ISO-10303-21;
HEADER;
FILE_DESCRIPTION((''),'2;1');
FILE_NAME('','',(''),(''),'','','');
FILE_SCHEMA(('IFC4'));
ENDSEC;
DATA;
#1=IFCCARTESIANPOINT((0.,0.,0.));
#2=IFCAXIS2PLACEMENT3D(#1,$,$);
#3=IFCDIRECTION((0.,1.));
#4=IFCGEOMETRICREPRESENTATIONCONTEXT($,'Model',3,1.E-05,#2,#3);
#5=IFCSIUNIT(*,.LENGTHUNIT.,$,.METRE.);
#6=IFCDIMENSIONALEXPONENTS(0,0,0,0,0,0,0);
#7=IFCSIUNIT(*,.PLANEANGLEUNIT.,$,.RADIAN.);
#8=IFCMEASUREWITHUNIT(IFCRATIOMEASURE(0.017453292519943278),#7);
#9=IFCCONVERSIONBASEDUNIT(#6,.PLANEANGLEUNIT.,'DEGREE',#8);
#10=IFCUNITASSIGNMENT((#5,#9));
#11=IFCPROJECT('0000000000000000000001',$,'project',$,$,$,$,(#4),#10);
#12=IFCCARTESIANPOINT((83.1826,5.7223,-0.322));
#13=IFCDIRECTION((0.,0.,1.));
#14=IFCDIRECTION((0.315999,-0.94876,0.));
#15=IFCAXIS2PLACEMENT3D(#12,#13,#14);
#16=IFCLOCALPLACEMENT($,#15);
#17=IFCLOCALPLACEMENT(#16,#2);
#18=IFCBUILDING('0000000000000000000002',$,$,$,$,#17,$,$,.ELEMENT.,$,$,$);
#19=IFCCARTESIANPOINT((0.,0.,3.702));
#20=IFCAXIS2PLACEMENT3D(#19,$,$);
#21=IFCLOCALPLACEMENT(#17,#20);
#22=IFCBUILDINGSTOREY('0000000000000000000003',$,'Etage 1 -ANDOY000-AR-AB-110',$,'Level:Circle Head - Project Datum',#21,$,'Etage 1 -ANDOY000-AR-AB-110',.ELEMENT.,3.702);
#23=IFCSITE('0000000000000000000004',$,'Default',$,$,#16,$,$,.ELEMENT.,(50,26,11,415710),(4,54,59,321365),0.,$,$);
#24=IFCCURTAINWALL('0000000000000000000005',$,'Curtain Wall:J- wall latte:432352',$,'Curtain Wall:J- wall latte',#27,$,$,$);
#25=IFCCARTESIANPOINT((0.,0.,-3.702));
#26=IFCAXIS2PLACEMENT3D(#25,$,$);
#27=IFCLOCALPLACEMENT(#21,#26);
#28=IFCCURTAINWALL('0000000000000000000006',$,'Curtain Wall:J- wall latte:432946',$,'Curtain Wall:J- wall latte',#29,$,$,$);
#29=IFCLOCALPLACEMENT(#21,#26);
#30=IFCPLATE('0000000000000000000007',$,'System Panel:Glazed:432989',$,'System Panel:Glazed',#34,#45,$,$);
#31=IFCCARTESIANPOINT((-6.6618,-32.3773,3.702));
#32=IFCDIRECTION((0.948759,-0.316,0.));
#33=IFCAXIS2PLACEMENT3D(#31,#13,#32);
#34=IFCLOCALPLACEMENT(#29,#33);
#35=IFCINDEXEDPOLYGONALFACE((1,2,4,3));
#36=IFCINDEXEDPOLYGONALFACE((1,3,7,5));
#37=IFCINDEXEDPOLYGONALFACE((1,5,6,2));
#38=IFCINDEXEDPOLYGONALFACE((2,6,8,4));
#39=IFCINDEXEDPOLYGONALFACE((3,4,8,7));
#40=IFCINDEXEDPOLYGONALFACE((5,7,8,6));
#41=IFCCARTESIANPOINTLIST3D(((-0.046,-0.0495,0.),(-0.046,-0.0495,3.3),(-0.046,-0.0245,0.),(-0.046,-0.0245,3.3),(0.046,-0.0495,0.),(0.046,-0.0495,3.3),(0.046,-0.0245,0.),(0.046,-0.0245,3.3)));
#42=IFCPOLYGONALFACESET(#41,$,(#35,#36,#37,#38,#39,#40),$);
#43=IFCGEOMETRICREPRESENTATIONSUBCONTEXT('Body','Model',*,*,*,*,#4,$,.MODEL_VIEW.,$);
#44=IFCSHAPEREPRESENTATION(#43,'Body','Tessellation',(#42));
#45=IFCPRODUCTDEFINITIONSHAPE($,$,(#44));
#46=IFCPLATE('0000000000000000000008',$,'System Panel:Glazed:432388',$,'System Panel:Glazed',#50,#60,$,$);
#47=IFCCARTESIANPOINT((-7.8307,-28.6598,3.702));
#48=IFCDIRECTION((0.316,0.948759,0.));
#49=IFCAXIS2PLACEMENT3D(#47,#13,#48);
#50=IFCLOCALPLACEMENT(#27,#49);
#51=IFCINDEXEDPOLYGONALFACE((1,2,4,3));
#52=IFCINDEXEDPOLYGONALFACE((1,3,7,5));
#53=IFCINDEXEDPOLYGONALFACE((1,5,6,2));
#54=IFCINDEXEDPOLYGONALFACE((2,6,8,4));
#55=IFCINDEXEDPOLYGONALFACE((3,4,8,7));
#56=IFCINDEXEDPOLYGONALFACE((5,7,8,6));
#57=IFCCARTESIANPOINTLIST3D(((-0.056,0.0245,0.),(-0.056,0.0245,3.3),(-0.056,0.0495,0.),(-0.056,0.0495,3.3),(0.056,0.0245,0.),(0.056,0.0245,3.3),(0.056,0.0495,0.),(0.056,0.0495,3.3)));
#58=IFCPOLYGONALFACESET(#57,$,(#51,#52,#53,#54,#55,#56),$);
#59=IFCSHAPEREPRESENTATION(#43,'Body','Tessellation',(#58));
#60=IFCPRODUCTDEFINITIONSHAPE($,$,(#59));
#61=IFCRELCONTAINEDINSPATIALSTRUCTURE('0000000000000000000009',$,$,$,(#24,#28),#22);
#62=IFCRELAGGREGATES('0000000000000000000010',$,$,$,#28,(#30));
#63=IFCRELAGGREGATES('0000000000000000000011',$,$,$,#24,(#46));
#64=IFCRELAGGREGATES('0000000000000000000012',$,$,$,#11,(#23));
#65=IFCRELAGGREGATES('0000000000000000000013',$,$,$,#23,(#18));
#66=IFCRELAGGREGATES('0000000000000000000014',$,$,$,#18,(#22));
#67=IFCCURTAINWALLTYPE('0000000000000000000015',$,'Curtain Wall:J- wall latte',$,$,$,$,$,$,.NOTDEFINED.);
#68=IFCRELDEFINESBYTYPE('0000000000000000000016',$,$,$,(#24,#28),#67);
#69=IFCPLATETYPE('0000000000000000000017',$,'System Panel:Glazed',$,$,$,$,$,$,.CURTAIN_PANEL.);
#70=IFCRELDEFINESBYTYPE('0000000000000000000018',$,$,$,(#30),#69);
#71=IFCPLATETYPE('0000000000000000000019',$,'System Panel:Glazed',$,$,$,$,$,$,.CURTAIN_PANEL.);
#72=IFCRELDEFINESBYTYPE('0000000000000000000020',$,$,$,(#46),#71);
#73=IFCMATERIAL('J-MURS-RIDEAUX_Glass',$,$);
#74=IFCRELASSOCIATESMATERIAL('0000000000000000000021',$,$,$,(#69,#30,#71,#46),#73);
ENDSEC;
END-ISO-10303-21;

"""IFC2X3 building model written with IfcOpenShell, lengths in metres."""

from ifc_helpers import new_model, entity, si_unit, converted_unit, direction, frame, frame_2d, origin, place, context, subcontext, project, spatial, rectangle, extrude, source, transform, mapped, material, type_object, type_shapes, element, aggregate, save


model = new_model("IFC2X3")

# Units and contexts
model_context = context("Model", 3, precision=1e-05, world=origin(), true_north=direction((0.0, 1.0)))
body_context = subcontext(model_context, "Body", "Model", "MODEL_VIEW")
ifc_project = project(units=[si_unit("LENGTHUNIT", "METRE"), converted_unit("PLANEANGLEUNIT", "DEGREE", entity("IfcRatioMeasure", 0.017453292519943278), si_unit("PLANEANGLEUNIT", "RADIAN"), dimensions=[0, 0, 0, 0, 0, 0, 0])], contexts=[model_context])

# Site, building, storey
site_placement = place(None, frame((83.1826, 5.7223, -0.322), z_axis=(0.0, 0.0, 1.0), x_axis=(0.315999, -0.94876, 0.0)))
site = spatial("IfcSite", under=ifc_project, at=site_placement, Name="Default", CompositionType="ELEMENT", RefLatitude=(50, 26, 11, 415710), RefLongitude=(4, 54, 59, 321365), RefElevation=0.0)
building_placement = place(site_placement, origin())
building = spatial("IfcBuilding", under=site, at=building_placement, CompositionType="ELEMENT")
storey_placement = place(building_placement, frame((0.0, 0.0, 3.702)))
storey = spatial("IfcBuildingStorey", under=building, at=storey_placement, Name="Etage 1 -ANDOY000-AR-AB-110", ObjectType="Level:Circle Head - Project Datum", LongName="Etage 1 -ANDOY000-AR-AB-110", CompositionType="ELEMENT", Elevation=3.702)

# Curtain walls
curtain_wall_type = type_object("IfcCurtainWallType", Name="Curtain Wall:J- wall latte", PredefinedType="NOTDEFINED")
curtain_wall_1_placement = place(storey_placement, frame((0.0, 0.0, -3.702)))
curtain_wall_1 = element("IfcCurtainWall", 1, at=curtain_wall_1_placement, inside=storey, type_object=curtain_wall_type, Name="Curtain Wall:J- wall latte:432352", ObjectType="Curtain Wall:J- wall latte")
curtain_wall_2_placement = place(storey_placement, frame((0.0, 0.0, -3.702)))
curtain_wall_2 = element("IfcCurtainWall", 2, at=curtain_wall_2_placement, inside=storey, type_object=curtain_wall_type, Name="Curtain Wall:J- wall latte:432946", ObjectType="Curtain Wall:J- wall latte")

# Plates
ifc_material_1 = material(Name="J-MURS-RIDEAUX_Glass")
plate_type_1 = type_object("IfcPlateType", Name="System Panel:Glazed", PredefinedType="CURTAIN_PANEL", material=ifc_material_1)
shared_shape_1 = source(origin(), body_context, "Body", "SweptSolid", [
    extrude(rectangle(XDim=0.025, YDim=0.092, at=frame_2d((0.0, 0.0), x_axis=(1.0, 0.0))), frame((0.0, -0.037, 0.0), z_axis=(0.0, 0.0, 1.0), x_axis=(0.0, 1.0, 0.0)), (0.0, 0.0, 1.0), 3.3),
])
type_shapes(plate_type_1, [shared_shape_1])
plate_1_placement = place(curtain_wall_2_placement, frame((-6.6618, -32.3773, 3.702), z_axis=(0.0, 0.0, 1.0), x_axis=(0.948759, -0.316, 0.0)))
plate_1 = element("IfcPlate", 3, at=plate_1_placement, type_object=plate_type_1, material=ifc_material_1, Name="System Panel:Glazed:432989", ObjectType="System Panel:Glazed", context=body_context, shape_type="MappedRepresentation", body=[
    mapped(shared_shape_1, transform((0.0, 0.0, 0.0), scale=1.0)),
])
aggregate(curtain_wall_2, [plate_1])
plate_type_2 = type_object("IfcPlateType", Name="System Panel:Glazed", PredefinedType="CURTAIN_PANEL", material=ifc_material_1)
shared_shape_2 = source(origin(), body_context, "Body", "SweptSolid", [
    extrude(rectangle(XDim=0.025, YDim=0.112, at=frame_2d((0.0, 0.0), x_axis=(1.0, 0.0))), frame((0.0, 0.037, 0.0), z_axis=(0.0, 0.0, 1.0), x_axis=(0.0, 1.0, 0.0)), (0.0, 0.0, 1.0), 3.3),
])
type_shapes(plate_type_2, [shared_shape_2])
plate_2_placement = place(curtain_wall_1_placement, frame((-7.8307, -28.6598, 3.702), z_axis=(0.0, 0.0, 1.0), x_axis=(0.316, 0.948759, 0.0)))
plate_2 = element("IfcPlate", 4, at=plate_2_placement, type_object=plate_type_2, material=ifc_material_1, Name="System Panel:Glazed:432388", ObjectType="System Panel:Glazed", context=body_context, shape_type="MappedRepresentation", body=[
    mapped(shared_shape_2, transform((0.0, 0.0, 0.0), scale=1.0)),
])
aggregate(curtain_wall_1, [plate_2])

save(model, "model.ifc")
